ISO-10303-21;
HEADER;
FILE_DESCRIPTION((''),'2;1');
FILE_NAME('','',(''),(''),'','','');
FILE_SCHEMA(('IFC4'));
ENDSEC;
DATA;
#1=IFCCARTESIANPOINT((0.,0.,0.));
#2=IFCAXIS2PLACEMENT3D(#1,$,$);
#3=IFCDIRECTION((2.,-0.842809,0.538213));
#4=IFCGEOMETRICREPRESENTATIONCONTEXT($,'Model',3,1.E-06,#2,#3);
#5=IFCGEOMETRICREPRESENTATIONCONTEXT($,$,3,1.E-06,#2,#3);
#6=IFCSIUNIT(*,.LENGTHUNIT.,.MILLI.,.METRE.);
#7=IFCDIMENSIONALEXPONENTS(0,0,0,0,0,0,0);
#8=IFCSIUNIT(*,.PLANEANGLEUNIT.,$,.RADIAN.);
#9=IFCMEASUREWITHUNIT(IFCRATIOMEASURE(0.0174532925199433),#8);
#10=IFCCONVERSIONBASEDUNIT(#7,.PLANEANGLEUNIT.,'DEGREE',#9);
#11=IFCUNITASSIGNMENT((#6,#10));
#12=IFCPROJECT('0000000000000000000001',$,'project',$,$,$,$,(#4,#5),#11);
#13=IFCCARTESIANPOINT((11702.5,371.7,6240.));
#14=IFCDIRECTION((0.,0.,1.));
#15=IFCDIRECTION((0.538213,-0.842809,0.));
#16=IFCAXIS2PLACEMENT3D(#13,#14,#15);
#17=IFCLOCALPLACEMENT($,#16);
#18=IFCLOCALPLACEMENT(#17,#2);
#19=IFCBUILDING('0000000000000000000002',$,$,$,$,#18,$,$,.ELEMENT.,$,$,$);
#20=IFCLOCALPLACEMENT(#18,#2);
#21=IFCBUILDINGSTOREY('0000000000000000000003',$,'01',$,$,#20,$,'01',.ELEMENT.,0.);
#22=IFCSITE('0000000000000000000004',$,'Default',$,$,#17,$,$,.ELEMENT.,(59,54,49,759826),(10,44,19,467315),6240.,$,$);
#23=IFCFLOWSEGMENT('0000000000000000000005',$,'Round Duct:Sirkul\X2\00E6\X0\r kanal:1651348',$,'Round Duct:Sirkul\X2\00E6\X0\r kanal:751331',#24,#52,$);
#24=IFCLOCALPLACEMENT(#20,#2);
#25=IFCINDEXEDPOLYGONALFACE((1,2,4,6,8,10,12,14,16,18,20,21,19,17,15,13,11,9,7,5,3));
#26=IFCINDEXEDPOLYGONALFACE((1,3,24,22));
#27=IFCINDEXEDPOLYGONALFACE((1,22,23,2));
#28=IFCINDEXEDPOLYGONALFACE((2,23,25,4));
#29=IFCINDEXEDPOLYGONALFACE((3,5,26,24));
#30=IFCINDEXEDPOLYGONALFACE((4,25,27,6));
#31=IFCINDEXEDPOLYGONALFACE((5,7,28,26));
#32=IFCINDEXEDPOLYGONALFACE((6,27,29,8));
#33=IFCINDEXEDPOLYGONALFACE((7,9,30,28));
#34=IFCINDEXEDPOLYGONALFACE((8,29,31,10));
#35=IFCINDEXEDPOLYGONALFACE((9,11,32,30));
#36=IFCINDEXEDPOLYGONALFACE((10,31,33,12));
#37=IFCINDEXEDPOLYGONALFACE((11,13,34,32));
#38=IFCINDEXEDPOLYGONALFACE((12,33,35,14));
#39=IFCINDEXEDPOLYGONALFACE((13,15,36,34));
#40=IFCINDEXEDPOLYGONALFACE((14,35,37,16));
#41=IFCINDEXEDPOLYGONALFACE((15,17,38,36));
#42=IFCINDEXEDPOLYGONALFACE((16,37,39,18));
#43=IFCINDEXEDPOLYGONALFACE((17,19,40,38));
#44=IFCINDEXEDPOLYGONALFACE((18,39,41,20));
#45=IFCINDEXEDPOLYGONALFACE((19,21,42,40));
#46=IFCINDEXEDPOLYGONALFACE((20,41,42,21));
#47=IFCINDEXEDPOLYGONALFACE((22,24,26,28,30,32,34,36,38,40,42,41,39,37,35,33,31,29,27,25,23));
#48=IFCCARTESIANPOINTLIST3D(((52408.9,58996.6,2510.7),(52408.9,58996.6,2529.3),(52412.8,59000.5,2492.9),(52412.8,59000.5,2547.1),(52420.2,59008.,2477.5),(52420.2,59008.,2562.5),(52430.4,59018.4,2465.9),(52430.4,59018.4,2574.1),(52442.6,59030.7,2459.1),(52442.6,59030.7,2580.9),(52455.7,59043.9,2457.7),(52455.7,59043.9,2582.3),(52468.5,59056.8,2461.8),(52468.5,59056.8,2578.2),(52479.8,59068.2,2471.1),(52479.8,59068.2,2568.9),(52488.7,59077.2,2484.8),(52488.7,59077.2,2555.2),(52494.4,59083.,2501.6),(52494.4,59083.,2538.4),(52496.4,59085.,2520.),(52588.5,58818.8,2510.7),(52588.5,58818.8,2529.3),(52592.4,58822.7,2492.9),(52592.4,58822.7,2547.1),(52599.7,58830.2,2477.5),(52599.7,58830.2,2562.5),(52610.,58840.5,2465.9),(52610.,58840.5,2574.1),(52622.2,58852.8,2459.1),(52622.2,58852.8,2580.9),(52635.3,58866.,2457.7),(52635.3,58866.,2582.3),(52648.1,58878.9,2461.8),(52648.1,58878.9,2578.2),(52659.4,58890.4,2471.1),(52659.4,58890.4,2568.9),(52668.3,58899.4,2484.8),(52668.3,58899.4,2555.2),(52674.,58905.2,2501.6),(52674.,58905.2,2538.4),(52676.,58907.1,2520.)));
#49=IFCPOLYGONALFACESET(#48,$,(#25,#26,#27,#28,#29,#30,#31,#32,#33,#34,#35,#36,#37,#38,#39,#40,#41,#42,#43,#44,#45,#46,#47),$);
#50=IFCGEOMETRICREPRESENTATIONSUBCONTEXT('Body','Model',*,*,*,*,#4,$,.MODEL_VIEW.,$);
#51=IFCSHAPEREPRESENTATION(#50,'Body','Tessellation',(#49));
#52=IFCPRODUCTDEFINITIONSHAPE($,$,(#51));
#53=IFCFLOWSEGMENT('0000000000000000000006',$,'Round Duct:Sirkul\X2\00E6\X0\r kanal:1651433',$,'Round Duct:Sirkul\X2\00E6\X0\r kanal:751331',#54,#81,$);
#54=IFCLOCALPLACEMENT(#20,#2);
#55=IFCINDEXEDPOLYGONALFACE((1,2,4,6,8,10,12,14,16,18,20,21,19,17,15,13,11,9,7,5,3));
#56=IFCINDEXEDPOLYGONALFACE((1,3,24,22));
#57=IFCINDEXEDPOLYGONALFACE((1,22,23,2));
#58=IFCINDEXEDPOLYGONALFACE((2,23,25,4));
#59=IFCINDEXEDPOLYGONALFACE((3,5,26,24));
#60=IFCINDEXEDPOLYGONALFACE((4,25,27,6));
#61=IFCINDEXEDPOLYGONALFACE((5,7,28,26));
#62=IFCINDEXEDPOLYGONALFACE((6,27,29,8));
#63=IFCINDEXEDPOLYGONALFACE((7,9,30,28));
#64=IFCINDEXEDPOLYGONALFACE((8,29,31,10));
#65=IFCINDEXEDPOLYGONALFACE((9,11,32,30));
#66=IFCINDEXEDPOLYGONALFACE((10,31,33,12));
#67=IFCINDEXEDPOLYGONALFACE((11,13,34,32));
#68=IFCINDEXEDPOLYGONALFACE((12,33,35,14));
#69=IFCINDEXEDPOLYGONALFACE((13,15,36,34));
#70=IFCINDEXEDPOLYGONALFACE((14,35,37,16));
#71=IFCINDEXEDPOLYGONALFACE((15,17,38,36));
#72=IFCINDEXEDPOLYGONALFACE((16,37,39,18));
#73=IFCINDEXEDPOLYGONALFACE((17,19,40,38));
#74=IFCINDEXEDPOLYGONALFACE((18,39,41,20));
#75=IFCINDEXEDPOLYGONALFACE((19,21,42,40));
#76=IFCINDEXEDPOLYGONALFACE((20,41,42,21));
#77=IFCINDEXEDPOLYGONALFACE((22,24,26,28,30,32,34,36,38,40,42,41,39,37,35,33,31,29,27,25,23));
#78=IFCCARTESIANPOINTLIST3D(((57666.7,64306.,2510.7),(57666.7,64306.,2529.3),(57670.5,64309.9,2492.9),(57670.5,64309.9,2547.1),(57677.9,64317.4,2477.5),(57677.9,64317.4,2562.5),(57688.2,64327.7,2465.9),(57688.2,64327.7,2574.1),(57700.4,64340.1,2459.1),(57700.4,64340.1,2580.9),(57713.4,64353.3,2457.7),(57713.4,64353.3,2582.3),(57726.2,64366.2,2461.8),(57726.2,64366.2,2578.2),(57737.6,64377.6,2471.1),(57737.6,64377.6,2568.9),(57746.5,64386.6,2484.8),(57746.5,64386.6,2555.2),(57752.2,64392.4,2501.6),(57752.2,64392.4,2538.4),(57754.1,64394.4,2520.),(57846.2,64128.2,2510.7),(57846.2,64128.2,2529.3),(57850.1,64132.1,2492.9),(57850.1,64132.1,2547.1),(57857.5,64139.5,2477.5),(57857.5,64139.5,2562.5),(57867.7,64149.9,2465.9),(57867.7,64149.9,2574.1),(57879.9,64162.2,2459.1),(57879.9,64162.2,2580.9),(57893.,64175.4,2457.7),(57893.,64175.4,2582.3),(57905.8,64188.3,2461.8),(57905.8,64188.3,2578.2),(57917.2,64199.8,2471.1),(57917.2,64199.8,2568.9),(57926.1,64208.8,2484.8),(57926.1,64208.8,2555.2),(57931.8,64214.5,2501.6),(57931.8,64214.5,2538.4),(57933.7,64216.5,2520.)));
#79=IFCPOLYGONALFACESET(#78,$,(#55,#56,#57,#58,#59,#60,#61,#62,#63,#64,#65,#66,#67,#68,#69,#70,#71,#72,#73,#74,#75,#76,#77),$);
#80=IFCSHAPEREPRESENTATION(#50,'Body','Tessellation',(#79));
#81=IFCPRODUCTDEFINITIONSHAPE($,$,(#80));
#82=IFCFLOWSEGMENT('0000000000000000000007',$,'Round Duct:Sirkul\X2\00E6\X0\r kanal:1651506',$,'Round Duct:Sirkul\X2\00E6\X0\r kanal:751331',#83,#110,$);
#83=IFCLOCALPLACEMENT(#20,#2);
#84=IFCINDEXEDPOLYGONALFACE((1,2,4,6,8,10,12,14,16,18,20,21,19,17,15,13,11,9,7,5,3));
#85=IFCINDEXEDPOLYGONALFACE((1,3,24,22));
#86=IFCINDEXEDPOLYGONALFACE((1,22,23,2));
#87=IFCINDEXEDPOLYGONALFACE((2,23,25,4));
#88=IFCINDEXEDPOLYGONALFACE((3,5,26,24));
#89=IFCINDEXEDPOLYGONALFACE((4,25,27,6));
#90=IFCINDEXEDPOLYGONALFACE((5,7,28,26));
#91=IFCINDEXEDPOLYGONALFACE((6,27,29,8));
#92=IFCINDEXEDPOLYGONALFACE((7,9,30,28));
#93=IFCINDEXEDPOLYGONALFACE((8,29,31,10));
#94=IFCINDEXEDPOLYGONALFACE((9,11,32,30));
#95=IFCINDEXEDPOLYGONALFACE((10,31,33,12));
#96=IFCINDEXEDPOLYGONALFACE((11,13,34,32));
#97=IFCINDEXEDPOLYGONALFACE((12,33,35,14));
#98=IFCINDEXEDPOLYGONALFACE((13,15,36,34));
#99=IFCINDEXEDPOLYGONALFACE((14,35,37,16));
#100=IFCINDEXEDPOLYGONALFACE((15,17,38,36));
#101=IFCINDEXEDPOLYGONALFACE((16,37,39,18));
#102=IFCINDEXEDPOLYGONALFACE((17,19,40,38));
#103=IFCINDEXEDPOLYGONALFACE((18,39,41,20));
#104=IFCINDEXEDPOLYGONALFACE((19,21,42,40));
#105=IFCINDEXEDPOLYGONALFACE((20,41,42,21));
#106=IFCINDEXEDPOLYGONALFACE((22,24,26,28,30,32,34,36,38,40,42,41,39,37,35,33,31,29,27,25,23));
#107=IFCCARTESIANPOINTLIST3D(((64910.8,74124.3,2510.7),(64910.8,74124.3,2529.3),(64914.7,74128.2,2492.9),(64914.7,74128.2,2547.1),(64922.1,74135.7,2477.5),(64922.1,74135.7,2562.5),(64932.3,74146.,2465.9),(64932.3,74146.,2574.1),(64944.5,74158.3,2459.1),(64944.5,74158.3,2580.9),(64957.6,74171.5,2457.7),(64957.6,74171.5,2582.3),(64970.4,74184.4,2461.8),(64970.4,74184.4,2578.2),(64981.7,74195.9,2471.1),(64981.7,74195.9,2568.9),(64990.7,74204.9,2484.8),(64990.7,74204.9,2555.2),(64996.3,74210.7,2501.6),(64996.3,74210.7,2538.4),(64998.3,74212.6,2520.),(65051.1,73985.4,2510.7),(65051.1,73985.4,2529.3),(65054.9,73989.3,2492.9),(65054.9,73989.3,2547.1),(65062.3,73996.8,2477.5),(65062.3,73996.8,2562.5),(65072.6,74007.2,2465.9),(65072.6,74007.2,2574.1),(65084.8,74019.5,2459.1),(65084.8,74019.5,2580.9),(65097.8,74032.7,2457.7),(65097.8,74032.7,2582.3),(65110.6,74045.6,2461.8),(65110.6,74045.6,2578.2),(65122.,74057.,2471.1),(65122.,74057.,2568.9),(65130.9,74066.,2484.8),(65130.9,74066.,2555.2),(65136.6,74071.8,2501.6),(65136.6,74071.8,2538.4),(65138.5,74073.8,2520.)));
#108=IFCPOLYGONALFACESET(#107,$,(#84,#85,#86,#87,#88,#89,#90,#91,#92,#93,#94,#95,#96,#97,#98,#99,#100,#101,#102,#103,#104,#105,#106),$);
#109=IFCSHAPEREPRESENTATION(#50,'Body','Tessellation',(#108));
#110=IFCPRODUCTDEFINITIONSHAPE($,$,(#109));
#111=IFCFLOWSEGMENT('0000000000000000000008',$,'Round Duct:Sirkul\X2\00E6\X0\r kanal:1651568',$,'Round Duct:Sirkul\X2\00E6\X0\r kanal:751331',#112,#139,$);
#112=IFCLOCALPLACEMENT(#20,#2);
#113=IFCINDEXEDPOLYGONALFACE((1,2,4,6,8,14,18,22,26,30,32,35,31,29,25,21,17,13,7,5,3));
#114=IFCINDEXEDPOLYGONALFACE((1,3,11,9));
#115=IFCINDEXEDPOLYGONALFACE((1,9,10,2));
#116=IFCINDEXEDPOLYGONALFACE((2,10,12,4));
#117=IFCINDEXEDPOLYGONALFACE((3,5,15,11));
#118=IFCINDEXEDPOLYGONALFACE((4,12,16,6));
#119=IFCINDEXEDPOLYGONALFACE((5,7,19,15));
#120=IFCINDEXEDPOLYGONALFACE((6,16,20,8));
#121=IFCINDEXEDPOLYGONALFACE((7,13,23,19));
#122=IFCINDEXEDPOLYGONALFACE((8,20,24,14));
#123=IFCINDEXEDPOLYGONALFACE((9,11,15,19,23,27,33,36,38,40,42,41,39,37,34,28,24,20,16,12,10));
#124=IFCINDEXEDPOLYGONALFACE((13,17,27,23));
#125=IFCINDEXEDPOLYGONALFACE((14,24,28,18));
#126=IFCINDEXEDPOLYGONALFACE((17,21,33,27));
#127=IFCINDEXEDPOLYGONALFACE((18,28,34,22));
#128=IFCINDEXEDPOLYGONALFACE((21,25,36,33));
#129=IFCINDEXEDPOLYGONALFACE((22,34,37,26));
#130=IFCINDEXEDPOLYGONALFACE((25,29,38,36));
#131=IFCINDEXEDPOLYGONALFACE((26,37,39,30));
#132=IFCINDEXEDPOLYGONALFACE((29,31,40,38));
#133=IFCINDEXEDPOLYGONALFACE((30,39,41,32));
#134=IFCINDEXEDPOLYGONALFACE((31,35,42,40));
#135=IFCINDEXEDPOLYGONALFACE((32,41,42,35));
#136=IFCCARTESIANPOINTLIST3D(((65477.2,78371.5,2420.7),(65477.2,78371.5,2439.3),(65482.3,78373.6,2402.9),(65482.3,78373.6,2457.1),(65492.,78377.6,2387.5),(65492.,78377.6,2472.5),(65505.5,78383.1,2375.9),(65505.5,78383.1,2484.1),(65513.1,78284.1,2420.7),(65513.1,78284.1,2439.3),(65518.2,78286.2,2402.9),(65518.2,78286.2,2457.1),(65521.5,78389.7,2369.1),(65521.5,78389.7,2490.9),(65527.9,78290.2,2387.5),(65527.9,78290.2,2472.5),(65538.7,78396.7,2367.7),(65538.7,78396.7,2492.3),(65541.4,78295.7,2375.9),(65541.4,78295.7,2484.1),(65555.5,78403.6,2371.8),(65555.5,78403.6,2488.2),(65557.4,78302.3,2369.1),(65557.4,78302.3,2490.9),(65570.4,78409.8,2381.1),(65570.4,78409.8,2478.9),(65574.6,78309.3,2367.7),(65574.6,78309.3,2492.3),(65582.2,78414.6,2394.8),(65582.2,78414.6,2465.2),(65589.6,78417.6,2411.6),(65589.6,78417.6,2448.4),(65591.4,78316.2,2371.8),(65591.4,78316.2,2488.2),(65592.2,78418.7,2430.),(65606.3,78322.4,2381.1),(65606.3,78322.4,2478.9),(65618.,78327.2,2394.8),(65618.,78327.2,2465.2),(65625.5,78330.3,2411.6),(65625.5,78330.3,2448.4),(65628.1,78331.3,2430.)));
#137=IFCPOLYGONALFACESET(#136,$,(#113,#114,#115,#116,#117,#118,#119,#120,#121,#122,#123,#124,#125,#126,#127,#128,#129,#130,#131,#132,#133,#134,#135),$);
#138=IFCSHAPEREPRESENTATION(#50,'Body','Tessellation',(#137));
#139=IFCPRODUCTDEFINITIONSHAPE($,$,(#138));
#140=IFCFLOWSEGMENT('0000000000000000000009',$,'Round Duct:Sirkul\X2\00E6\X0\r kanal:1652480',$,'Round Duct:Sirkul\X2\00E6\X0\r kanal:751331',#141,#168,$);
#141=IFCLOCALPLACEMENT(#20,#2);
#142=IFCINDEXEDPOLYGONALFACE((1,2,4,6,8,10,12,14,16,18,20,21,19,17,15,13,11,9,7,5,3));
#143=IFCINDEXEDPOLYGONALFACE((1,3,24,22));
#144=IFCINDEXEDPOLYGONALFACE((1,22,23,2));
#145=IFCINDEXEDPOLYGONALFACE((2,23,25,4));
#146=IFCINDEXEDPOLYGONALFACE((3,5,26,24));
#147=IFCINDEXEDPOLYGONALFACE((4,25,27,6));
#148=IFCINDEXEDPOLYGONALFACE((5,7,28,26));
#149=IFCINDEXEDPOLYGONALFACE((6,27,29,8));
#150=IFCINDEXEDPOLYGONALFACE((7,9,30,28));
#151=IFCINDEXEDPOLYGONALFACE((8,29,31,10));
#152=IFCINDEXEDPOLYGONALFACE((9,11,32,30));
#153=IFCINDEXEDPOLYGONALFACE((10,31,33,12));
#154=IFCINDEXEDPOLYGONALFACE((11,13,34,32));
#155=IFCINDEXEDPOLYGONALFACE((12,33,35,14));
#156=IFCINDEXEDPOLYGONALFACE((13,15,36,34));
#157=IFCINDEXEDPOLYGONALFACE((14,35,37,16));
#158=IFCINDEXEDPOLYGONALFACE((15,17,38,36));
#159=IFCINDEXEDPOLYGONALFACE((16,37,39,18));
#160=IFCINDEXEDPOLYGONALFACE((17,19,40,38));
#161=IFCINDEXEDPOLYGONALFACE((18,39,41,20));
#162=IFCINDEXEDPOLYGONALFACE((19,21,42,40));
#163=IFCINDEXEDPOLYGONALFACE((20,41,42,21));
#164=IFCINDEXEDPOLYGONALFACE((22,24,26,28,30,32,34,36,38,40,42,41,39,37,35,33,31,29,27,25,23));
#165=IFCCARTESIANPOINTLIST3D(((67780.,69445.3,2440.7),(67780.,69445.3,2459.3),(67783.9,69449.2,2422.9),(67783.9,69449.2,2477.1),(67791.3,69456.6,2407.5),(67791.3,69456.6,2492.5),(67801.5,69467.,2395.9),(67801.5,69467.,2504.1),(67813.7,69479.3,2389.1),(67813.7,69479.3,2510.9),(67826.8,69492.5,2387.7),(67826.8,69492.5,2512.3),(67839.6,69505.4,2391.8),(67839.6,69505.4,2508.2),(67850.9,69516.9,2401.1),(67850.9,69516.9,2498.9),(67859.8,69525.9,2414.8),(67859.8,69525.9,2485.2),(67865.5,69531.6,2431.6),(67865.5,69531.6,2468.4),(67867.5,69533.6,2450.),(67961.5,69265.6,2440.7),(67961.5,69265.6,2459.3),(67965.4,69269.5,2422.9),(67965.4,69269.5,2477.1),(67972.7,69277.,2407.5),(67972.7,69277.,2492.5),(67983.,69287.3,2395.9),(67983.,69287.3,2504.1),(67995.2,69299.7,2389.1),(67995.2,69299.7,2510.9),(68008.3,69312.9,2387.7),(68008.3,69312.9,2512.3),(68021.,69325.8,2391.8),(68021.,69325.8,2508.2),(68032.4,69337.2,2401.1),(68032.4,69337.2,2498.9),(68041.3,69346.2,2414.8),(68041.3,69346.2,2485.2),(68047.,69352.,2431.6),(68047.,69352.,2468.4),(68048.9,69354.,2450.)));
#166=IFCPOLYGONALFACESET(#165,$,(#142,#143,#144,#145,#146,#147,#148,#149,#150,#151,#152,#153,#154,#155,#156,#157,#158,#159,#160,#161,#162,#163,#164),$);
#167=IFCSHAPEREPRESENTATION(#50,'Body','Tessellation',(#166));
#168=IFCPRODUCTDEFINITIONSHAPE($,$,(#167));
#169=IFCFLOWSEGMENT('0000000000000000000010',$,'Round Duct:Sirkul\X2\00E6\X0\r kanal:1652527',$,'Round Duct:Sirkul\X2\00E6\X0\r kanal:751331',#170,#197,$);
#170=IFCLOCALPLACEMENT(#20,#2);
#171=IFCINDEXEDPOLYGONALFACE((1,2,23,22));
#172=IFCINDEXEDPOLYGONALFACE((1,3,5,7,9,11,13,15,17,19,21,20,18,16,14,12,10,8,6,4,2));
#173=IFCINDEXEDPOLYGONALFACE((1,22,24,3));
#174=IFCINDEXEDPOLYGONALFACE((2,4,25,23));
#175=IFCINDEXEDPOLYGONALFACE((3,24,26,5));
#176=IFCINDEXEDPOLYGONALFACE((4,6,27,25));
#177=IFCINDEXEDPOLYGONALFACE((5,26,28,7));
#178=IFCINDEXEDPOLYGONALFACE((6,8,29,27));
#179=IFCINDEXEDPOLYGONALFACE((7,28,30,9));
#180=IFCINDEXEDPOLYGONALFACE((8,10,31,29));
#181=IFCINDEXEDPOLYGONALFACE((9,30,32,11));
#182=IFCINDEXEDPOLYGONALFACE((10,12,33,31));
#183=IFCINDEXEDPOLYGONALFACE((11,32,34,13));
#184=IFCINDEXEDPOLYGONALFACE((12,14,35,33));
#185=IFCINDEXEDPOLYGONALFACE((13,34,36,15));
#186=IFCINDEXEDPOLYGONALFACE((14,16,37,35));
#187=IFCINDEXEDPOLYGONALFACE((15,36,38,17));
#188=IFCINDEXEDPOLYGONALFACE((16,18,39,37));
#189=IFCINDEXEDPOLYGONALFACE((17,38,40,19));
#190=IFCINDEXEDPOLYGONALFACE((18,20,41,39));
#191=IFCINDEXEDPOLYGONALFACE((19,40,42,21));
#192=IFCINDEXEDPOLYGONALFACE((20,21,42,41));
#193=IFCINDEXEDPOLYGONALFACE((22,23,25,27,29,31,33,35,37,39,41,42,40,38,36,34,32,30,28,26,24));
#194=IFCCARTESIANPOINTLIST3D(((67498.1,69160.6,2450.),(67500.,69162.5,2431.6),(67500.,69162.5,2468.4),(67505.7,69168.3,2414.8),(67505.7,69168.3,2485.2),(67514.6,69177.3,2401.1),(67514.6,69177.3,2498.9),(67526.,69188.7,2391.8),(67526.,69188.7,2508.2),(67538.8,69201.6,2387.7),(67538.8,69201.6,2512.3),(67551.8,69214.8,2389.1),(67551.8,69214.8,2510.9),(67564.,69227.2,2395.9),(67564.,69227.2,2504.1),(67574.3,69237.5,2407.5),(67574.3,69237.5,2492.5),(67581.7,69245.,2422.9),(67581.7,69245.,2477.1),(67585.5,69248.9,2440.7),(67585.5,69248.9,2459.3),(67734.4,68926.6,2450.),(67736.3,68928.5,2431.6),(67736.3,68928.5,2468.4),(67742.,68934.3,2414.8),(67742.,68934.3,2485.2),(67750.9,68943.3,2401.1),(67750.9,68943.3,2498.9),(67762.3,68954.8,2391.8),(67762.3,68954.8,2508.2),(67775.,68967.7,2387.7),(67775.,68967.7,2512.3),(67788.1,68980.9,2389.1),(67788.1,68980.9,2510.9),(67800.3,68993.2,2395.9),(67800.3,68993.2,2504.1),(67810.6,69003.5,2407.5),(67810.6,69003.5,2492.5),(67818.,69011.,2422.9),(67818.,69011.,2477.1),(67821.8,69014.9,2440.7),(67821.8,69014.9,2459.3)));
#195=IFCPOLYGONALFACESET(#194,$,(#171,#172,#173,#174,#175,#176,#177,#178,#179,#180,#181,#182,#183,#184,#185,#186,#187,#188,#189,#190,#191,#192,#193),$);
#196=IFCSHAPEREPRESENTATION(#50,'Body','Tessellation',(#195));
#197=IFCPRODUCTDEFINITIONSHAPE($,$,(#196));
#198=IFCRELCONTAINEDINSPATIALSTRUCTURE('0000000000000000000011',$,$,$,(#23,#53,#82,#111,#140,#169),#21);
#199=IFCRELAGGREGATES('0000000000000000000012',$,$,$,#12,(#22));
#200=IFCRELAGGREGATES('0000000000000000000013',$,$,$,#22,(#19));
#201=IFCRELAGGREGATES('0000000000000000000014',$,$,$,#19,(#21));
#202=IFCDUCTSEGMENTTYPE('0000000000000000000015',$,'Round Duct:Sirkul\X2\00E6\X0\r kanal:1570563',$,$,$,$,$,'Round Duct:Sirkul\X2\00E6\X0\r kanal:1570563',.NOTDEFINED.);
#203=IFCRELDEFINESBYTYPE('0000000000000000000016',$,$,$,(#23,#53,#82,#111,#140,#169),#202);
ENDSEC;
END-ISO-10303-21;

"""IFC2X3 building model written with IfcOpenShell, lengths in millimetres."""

from ifc_helpers import new_model, entity, si_unit, converted_unit, direction, frame, frame_2d, origin, origin_2d_with_axis, place, context, subcontext, project, spatial, circle, extrude, type_object, element, save


model = new_model("IFC2X3")

# Units and contexts
model_context = context("Model", 3, precision=1e-06, world=origin(), true_north=direction((2.0, -0.842809, 0.538213)))
context_of_model = context(None, 3, precision=1e-06, world=origin(), true_north=direction((2.0, -0.842809, 0.538213)))
body_context = subcontext(model_context, "Body", "Model", "MODEL_VIEW")
ifc_project = project(units=[si_unit("LENGTHUNIT", "METRE", prefix="MILLI"), converted_unit("PLANEANGLEUNIT", "DEGREE", entity("IfcRatioMeasure", 0.0174532925199433), si_unit("PLANEANGLEUNIT", "RADIAN"), dimensions=[0, 0, 0, 0, 0, 0, 0])], contexts=[model_context, context_of_model])

# Site, building, storey
site_placement = place(None, frame((11702.5, 371.7, 6240.0), z_axis=(0.0, 0.0, 1.0), x_axis=(0.538213, -0.842809, 0.0)))
site = spatial("IfcSite", under=ifc_project, at=site_placement, Name="Default", CompositionType="ELEMENT", RefLatitude=(59, 54, 49, 759826), RefLongitude=(10, 44, 19, 467315), RefElevation=6240.0)
building_placement = place(site_placement, origin())
building = spatial("IfcBuilding", under=site, at=building_placement, CompositionType="ELEMENT")
storey_placement = place(building_placement, origin())
storey = spatial("IfcBuildingStorey", under=building, at=storey_placement, Name="01", LongName="01", CompositionType="ELEMENT", Elevation=0.0)

# Flow segments
duct_segment_type = type_object("IfcDuctSegmentType", Name="Round Duct:Sirkulær kanal:1570563", ElementType="Round Duct:Sirkulær kanal:1570563", PredefinedType="NOTDEFINED")
flow_segment_1_placement = place(storey_placement, origin())
element("IfcFlowSegment", 1, at=flow_segment_1_placement, inside=storey, type_object=duct_segment_type, Name="Round Duct:Sirkulær kanal:1651348", ObjectType="Round Duct:Sirkulær kanal:751331", context=body_context, shape_type="SweptSolid", body=[
    extrude(circle(Radius=62.5, at=frame_2d((0.0, 0.0), x_axis=(1.0, 0.0))), frame((52632.0, 58862.7, 2520.0), z_axis=(-0.710554, 0.703643, 0.0), x_axis=(0.703643, 0.710554, 0.0)), (0.0, 0.0, 1.0), 252.7),
])
flow_segment_2_placement = place(storey_placement, origin())
element("IfcFlowSegment", 2, at=flow_segment_2_placement, inside=storey, type_object=duct_segment_type, Name="Round Duct:Sirkulær kanal:1651433", ObjectType="Round Duct:Sirkulær kanal:751331", context=body_context, shape_type="SweptSolid", body=[
    extrude(circle(Radius=62.5, at=origin_2d_with_axis()), frame((57710.1, 64349.9, 2520.0), z_axis=(0.710554, -0.703643, 0.0), x_axis=(0.703643, 0.710554, 0.0)), (0.0, 0.0, 1.0), 252.7),
])
flow_segment_3_placement = place(storey_placement, origin())
element("IfcFlowSegment", 3, at=flow_segment_3_placement, inside=storey, type_object=duct_segment_type, Name="Round Duct:Sirkulær kanal:1651506", ObjectType="Round Duct:Sirkulær kanal:751331", context=body_context, shape_type="SweptSolid", body=[
    extrude(circle(Radius=62.5, at=origin_2d_with_axis()), frame((64954.3, 74168.2, 2520.0), z_axis=(0.710554, -0.703643, 0.0), x_axis=(0.703643, 0.710554, 0.0)), (0.0, 0.0, 1.0), 197.4),
])
flow_segment_4_placement = place(storey_placement, origin())
element("IfcFlowSegment", 4, at=flow_segment_4_placement, inside=storey, type_object=duct_segment_type, Name="Round Duct:Sirkulær kanal:1651568", ObjectType="Round Duct:Sirkulær kanal:751331", context=body_context, shape_type="SweptSolid", body=[
    extrude(circle(Radius=62.5, at=origin_2d_with_axis()), frame((65534.4, 78395.0, 2430.0), z_axis=(0.379807, -0.925066, 0.0), x_axis=(0.925066, 0.379807, 0.0)), (0.0, 0.0, 1.0), 94.5),
])
flow_segment_5_placement = place(storey_placement, origin())
element("IfcFlowSegment", 5, at=flow_segment_5_placement, inside=storey, type_object=duct_segment_type, Name="Round Duct:Sirkulær kanal:1652480", ObjectType="Round Duct:Sirkulær kanal:751331", context=body_context, shape_type="SweptSolid", body=[
    extrude(circle(Radius=62.5, at=origin_2d_with_axis()), frame((67823.5, 69489.2, 2450.0), z_axis=(0.710683, -0.703513, 0.0), x_axis=(0.703513, 0.710683, 0.0)), (0.0, 0.0, 1.0), 255.4),
])
flow_segment_6_placement = place(storey_placement, origin())
element("IfcFlowSegment", 6, at=flow_segment_6_placement, inside=storey, type_object=duct_segment_type, Name="Round Duct:Sirkulær kanal:1652527", ObjectType="Round Duct:Sirkulær kanal:751331", context=body_context, shape_type="SweptSolid", body=[
    extrude(circle(Radius=62.5, at=origin_2d_with_axis()), frame((67542.0, 69205.0, 2450.0), z_axis=(0.710554, -0.703643, 0.0), x_axis=(-0.703643, -0.710554, 0.0)), (0.0, 0.0, 1.0), 332.5),
])

save(model, "model.ifc")
